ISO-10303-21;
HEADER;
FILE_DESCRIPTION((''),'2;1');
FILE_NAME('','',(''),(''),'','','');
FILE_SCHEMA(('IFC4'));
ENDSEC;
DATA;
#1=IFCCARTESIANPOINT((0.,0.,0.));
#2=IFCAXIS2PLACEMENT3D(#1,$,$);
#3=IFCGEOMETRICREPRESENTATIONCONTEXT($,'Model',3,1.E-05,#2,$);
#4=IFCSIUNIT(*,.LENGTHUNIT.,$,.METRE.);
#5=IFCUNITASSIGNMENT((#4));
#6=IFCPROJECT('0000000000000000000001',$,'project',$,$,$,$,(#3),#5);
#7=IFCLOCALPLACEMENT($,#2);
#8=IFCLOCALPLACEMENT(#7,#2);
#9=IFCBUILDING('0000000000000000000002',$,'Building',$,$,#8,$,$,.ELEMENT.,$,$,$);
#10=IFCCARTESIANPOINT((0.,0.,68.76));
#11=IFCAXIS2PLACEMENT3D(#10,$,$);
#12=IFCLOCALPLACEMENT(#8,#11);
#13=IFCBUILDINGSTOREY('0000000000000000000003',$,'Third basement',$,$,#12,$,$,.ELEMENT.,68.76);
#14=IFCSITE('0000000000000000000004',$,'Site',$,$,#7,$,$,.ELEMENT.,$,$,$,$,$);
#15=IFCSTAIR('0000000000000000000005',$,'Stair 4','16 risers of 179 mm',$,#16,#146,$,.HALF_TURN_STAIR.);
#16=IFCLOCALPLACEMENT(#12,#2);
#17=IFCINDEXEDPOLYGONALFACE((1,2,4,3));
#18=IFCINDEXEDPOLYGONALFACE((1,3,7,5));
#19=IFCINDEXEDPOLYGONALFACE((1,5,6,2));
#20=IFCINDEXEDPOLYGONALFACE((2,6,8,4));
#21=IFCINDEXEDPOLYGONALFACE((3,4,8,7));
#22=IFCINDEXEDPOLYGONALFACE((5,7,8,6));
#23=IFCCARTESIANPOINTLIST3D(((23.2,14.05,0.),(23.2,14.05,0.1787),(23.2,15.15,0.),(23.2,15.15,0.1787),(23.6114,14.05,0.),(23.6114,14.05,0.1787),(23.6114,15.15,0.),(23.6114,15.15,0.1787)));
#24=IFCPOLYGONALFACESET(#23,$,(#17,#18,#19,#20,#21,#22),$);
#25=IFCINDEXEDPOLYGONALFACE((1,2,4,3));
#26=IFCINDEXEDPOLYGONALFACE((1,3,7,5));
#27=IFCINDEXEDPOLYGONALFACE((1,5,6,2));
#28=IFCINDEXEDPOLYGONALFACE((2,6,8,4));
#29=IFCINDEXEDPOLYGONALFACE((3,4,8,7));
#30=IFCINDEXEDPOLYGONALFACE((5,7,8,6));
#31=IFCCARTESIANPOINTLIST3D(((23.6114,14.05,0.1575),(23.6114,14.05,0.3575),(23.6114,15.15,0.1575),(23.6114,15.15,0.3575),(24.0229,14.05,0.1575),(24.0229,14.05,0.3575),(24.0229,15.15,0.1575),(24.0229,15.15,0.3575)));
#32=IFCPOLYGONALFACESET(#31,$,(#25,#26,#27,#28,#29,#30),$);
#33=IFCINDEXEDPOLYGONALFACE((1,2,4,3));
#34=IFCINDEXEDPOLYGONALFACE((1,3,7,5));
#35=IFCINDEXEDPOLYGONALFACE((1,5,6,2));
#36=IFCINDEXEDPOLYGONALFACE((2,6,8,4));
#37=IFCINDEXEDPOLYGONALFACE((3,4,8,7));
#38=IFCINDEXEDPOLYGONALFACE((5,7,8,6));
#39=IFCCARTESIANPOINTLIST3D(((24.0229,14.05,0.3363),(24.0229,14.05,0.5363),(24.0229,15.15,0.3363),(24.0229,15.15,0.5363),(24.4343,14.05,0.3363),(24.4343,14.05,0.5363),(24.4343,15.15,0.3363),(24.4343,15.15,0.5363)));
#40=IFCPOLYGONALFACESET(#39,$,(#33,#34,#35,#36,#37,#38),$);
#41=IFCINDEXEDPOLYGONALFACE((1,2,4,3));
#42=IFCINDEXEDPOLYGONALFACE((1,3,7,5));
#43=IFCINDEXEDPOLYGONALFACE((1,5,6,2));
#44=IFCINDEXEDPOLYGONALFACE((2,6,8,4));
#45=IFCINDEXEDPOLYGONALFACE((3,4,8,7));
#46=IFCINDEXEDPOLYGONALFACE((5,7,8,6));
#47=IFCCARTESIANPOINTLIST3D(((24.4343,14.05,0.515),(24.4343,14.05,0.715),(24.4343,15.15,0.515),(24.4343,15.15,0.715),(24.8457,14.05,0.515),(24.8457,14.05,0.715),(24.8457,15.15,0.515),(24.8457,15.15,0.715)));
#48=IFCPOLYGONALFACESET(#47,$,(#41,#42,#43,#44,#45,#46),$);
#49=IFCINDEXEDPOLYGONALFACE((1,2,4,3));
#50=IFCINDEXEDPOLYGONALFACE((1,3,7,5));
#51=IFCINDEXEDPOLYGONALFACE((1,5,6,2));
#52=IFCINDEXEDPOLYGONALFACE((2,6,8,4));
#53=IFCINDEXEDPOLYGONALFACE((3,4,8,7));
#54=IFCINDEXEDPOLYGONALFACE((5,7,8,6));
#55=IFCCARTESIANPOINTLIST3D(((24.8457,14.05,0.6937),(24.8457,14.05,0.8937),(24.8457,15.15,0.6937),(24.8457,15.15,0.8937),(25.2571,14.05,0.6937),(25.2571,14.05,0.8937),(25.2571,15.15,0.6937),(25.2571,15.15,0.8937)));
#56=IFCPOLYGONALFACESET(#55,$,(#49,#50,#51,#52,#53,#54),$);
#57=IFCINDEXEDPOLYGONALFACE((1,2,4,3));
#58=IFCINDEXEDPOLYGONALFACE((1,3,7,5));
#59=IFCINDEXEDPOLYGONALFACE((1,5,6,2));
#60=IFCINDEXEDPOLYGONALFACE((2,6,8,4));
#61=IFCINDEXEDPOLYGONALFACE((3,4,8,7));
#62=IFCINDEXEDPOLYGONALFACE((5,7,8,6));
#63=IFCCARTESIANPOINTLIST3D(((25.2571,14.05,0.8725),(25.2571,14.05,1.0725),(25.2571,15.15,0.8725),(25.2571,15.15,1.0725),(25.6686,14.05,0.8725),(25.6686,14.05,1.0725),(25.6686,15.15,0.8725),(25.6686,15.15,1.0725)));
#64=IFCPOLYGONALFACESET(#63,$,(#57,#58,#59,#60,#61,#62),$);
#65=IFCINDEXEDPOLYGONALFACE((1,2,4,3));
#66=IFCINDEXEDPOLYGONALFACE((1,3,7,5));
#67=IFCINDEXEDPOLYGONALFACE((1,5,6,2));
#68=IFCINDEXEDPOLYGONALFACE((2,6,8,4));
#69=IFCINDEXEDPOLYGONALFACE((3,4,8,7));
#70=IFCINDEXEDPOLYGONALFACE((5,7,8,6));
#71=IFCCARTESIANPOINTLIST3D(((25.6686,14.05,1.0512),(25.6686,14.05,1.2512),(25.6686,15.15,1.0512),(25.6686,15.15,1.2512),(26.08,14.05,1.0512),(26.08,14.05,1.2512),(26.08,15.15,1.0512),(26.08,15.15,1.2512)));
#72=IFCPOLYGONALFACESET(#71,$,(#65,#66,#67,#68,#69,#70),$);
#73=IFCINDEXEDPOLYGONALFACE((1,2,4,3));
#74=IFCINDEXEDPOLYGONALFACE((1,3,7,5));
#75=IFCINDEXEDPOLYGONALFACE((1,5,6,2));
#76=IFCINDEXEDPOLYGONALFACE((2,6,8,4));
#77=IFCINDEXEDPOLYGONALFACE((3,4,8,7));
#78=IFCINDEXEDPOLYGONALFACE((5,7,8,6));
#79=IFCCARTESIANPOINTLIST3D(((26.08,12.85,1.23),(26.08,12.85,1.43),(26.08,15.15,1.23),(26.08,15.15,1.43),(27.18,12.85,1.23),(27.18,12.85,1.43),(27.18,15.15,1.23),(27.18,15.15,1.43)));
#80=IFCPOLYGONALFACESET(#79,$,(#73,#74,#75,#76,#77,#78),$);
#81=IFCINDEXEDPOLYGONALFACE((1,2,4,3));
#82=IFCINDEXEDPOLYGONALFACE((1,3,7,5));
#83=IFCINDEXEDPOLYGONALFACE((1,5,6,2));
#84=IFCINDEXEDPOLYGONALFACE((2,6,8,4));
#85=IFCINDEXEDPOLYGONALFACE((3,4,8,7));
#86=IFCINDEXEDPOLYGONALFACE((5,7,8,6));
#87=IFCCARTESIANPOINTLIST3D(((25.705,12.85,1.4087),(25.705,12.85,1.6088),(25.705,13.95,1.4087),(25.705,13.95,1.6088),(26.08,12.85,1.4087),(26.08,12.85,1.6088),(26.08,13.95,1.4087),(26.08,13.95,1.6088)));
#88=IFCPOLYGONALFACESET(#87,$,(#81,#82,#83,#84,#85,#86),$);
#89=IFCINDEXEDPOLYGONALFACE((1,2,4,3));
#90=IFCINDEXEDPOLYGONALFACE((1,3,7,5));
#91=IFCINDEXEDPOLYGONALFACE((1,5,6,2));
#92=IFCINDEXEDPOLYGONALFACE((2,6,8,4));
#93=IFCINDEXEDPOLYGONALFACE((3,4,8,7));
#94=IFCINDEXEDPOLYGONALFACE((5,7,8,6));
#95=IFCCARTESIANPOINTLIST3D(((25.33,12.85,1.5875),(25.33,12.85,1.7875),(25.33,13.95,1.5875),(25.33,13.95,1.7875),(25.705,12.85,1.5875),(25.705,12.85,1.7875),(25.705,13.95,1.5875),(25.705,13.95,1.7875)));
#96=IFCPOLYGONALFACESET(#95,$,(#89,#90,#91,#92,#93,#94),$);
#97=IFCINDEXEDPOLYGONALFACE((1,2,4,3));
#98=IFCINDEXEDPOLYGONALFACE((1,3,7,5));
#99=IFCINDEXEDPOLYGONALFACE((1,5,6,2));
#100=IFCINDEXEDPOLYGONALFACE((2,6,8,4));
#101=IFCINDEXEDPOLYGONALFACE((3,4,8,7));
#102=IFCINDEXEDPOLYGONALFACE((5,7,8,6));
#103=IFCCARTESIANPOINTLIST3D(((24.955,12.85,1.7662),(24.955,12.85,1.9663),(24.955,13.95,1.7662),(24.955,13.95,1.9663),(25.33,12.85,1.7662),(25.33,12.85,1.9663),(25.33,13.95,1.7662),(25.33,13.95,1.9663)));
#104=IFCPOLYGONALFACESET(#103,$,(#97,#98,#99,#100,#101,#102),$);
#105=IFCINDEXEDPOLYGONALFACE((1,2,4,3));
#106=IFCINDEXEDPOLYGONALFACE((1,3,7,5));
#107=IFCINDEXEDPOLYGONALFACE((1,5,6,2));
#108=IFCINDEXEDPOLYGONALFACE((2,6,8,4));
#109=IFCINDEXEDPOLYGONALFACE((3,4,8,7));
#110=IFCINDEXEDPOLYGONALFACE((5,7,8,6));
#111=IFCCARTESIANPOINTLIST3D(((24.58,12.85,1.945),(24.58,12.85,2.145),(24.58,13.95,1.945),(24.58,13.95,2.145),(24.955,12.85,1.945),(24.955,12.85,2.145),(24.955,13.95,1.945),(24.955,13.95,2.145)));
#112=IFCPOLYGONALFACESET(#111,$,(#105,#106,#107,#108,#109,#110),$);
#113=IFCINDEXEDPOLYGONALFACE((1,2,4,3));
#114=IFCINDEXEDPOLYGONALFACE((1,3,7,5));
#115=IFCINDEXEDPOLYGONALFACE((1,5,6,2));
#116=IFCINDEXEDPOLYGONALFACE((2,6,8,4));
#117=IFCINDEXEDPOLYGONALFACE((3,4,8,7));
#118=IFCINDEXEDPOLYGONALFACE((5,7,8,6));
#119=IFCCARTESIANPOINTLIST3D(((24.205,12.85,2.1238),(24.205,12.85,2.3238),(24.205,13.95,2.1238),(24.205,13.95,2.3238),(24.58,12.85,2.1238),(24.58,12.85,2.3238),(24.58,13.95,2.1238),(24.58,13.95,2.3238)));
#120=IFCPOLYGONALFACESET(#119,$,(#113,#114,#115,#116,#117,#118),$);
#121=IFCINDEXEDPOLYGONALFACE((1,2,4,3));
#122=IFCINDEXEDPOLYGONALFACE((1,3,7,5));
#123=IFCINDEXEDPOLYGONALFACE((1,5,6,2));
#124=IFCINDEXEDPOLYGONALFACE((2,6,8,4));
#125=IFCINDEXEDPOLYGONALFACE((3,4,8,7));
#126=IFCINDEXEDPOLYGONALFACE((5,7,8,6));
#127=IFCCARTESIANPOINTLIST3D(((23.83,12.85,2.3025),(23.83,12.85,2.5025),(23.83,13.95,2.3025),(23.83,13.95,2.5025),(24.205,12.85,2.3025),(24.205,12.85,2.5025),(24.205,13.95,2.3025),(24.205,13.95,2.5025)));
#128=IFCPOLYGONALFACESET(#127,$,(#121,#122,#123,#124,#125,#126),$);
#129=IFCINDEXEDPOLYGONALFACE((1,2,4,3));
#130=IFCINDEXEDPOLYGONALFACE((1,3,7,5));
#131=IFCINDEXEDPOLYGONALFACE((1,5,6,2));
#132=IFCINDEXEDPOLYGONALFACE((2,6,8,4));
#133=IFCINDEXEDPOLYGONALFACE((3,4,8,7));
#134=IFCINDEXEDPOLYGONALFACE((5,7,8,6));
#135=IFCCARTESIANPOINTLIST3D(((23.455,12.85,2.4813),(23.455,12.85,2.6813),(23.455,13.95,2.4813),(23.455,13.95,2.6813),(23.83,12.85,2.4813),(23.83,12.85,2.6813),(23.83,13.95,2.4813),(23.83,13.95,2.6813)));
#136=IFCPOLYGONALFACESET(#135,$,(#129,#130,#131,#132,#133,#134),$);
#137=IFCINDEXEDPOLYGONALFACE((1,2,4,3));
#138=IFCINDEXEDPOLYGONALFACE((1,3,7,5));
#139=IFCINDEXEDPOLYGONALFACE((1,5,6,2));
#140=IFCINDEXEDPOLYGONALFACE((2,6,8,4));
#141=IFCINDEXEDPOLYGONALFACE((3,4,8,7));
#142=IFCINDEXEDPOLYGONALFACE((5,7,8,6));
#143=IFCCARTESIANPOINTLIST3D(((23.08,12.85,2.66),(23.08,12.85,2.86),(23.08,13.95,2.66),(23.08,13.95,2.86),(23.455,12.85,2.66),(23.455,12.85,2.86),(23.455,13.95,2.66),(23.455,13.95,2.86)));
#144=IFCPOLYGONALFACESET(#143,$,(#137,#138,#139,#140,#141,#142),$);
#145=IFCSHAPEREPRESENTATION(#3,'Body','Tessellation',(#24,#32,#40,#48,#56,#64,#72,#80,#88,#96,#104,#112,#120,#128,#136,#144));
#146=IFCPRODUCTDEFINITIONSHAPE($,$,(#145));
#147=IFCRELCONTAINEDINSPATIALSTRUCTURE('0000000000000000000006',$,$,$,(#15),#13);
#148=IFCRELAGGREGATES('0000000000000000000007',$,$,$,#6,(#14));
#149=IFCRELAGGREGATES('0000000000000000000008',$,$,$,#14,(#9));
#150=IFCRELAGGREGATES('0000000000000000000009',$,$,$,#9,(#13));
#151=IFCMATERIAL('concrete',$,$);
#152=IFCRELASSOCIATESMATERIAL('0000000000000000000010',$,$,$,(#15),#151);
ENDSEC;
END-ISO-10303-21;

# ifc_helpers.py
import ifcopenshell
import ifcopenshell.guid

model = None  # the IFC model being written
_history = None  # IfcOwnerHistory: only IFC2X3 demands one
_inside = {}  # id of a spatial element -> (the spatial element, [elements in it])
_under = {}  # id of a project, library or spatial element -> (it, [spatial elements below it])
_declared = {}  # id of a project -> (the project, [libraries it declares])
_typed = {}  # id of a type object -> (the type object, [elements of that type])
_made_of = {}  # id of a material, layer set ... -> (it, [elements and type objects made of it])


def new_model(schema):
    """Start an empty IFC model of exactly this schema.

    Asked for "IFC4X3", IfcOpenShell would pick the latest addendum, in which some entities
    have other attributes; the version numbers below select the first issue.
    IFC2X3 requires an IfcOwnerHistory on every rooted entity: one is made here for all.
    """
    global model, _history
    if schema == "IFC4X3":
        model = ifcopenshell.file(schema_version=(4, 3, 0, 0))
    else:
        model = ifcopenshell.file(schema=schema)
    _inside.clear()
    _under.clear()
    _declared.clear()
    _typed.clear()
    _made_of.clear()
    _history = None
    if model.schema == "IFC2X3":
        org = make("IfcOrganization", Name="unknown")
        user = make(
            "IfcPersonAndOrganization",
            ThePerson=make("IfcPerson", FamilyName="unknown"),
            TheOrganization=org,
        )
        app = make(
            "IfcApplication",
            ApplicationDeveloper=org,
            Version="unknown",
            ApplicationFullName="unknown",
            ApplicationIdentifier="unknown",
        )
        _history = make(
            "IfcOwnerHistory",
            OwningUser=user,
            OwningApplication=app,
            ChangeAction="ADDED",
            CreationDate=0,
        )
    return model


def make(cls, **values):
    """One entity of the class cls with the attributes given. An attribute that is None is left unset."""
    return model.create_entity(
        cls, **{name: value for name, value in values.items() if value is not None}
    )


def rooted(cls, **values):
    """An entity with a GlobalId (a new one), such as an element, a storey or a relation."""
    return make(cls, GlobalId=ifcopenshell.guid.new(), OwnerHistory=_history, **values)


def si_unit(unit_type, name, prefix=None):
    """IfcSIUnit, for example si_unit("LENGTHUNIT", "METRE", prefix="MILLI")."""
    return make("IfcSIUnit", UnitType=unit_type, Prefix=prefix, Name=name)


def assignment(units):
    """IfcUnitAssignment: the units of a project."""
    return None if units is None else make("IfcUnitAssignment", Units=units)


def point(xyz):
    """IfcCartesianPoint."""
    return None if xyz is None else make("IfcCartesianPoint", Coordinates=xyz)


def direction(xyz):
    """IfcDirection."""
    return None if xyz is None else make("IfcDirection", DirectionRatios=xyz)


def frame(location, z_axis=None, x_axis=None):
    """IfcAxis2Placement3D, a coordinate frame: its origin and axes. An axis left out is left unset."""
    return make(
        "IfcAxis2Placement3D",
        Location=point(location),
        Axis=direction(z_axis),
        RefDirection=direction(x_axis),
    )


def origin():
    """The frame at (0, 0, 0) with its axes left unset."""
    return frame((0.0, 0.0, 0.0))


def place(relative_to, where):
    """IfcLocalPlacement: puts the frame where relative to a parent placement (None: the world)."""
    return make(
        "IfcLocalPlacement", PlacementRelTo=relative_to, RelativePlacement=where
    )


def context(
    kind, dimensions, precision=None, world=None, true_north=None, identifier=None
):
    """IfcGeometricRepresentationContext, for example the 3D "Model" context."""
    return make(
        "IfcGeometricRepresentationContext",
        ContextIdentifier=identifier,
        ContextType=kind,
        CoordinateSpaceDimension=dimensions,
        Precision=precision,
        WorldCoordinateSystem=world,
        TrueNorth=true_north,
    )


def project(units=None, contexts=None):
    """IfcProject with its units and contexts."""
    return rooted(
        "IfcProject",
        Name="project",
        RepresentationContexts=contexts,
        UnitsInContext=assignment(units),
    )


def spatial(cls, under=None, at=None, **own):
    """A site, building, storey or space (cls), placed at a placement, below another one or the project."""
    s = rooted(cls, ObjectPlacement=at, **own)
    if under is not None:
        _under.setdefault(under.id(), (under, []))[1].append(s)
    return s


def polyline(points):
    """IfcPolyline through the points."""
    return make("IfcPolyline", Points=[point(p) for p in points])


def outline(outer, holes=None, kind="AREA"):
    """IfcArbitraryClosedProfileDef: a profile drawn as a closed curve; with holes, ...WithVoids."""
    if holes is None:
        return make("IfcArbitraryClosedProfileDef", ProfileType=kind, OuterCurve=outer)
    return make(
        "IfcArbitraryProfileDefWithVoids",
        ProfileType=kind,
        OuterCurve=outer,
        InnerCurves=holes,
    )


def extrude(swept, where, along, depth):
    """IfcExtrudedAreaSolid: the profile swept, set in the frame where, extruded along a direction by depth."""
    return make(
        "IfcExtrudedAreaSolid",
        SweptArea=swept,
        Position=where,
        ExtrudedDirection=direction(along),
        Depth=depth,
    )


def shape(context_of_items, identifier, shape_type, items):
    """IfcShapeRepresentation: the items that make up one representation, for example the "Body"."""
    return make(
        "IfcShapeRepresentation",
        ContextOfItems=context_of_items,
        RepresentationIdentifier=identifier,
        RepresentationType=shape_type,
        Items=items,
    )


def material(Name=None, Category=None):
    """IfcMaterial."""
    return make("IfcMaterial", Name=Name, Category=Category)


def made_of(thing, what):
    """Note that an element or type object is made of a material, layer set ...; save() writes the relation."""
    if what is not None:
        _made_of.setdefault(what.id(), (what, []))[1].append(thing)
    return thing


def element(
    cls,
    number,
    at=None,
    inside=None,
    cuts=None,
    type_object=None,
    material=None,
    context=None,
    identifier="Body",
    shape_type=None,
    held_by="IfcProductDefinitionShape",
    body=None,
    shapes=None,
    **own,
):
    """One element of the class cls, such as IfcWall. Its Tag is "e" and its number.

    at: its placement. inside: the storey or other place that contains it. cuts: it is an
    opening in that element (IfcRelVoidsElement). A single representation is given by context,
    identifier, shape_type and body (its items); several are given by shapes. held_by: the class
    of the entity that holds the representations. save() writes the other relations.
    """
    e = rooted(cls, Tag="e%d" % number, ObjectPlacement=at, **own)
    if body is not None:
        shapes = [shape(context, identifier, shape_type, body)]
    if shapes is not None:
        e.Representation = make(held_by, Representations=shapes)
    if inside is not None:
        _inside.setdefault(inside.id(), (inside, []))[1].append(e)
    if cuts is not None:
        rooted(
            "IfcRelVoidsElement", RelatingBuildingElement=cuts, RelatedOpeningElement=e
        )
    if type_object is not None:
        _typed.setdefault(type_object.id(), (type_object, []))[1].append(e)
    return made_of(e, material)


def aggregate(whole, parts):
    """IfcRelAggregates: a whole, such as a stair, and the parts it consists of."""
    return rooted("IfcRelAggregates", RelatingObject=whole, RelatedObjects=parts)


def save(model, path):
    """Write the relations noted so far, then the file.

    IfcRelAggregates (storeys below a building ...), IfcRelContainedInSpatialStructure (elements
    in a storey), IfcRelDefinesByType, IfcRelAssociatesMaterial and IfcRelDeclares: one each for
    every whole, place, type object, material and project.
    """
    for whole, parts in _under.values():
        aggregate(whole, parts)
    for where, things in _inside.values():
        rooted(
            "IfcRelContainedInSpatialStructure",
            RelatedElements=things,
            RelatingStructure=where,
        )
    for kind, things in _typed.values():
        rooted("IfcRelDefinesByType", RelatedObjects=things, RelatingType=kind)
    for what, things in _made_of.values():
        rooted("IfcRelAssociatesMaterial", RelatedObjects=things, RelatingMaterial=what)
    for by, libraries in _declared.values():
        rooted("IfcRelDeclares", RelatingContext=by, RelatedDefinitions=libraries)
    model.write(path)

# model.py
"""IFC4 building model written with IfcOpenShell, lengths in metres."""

from ifc_helpers import new_model, si_unit, frame, origin, place, context, project, spatial, polyline, outline, extrude, material, element, save


model = new_model("IFC4")

# Units and contexts
model_context = context("Model", 3, precision=1e-05, world=origin())
ifc_project = project(units=[si_unit("LENGTHUNIT", "METRE")], contexts=[model_context])

# Site, building, storey
site_placement = place(None, origin())
site = spatial("IfcSite", under=ifc_project, at=site_placement, Name="Site", CompositionType="ELEMENT")
building_placement = place(site_placement, origin())
building = spatial("IfcBuilding", under=site, at=building_placement, Name="Building", CompositionType="ELEMENT")
storey_placement = place(building_placement, frame((0.0, 0.0, 68.76)))
storey = spatial("IfcBuildingStorey", under=building, at=storey_placement, Name="Third basement", CompositionType="ELEMENT", Elevation=68.76)

# Shared definitions
ifc_material = material(Name="concrete")

# Stair
stair_1_placement = place(storey_placement, frame((23.2, 14.6, 0.0), z_axis=(0.0, 0.0, 1.0), x_axis=(1.0, 0.0, 0.0)))
element("IfcStair", 1, at=stair_1_placement, inside=storey, material=ifc_material, Name="Stair 4", Description="16 risers of 179 mm", PredefinedType="HALF_TURN_STAIR", context=model_context, shape_type="SweptSolid", body=[
    extrude(outline(polyline([(0.0, -0.55), (0.4114, -0.55), (0.4114, 0.55), (0.0, 0.55), (0.0, -0.55)])), origin(), (0.0, 0.0, 1.0), 0.1787),
    extrude(outline(polyline([(0.4114, -0.55), (0.8229, -0.55), (0.8229, 0.55), (0.4114, 0.55), (0.4114, -0.55)])), frame((0.0, 0.0, 0.1575)), (0.0, 0.0, 1.0), 0.2),
    extrude(outline(polyline([(0.8229, -0.55), (1.2343, -0.55), (1.2343, 0.55), (0.8229, 0.55), (0.8229, -0.55)])), frame((0.0, 0.0, 0.3362)), (0.0, 0.0, 1.0), 0.2),
    extrude(outline(polyline([(1.2343, -0.55), (1.6457, -0.55), (1.6457, 0.55), (1.2343, 0.55), (1.2343, -0.55)])), frame((0.0, 0.0, 0.515)), (0.0, 0.0, 1.0), 0.2),
    extrude(outline(polyline([(1.6457, -0.55), (2.0571, -0.55), (2.0571, 0.55), (1.6457, 0.55), (1.6457, -0.55)])), frame((0.0, 0.0, 0.6937)), (0.0, 0.0, 1.0), 0.2),
    extrude(outline(polyline([(2.0571, -0.55), (2.4686, -0.55), (2.4686, 0.55), (2.0571, 0.55), (2.0571, -0.55)])), frame((0.0, 0.0, 0.8725)), (0.0, 0.0, 1.0), 0.2),
    extrude(outline(polyline([(2.4686, -0.55), (2.88, -0.55), (2.88, 0.55), (2.4686, 0.55), (2.4686, -0.55)])), frame((0.0, 0.0, 1.0513)), (0.0, 0.0, 1.0), 0.2),
    extrude(outline(polyline([(2.88, -1.75), (3.98, -1.75), (3.98, 0.55), (2.88, 0.55), (2.88, -1.75)])), frame((0.0, 0.0, 1.23)), (0.0, 0.0, 1.0), 0.2),
    extrude(outline(polyline([(2.505, -1.75), (2.88, -1.75), (2.88, -0.65), (2.505, -0.65), (2.505, -1.75)])), frame((0.0, 0.0, 1.4087)), (0.0, 0.0, 1.0), 0.2),
    extrude(outline(polyline([(2.13, -1.75), (2.505, -1.75), (2.505, -0.65), (2.13, -0.65), (2.13, -1.75)])), frame((0.0, 0.0, 1.5875)), (0.0, 0.0, 1.0), 0.2),
    extrude(outline(polyline([(1.755, -1.75), (2.13, -1.75), (2.13, -0.65), (1.755, -0.65), (1.755, -1.75)])), frame((0.0, 0.0, 1.7663)), (0.0, 0.0, 1.0), 0.2),
    extrude(outline(polyline([(1.38, -1.75), (1.755, -1.75), (1.755, -0.65), (1.38, -0.65), (1.38, -1.75)])), frame((0.0, 0.0, 1.945)), (0.0, 0.0, 1.0), 0.2),
    extrude(outline(polyline([(1.005, -1.75), (1.38, -1.75), (1.38, -0.65), (1.005, -0.65), (1.005, -1.75)])), frame((0.0, 0.0, 2.1237)), (0.0, 0.0, 1.0), 0.2),
    extrude(outline(polyline([(0.63, -1.75), (1.005, -1.75), (1.005, -0.65), (0.63, -0.65), (0.63, -1.75)])), frame((0.0, 0.0, 2.3025)), (0.0, 0.0, 1.0), 0.2),
    extrude(outline(polyline([(0.255, -1.75), (0.63, -1.75), (0.63, -0.65), (0.255, -0.65), (0.255, -1.75)])), frame((0.0, 0.0, 2.4813)), (0.0, 0.0, 1.0), 0.2),
    extrude(outline(polyline([(-0.12, -1.75), (0.255, -1.75), (0.255, -0.65), (-0.12, -0.65), (-0.12, -1.75)])), frame((0.0, 0.0, 2.66)), (0.0, 0.0, 1.0), 0.2),
])

save(model, "model.ifc")
